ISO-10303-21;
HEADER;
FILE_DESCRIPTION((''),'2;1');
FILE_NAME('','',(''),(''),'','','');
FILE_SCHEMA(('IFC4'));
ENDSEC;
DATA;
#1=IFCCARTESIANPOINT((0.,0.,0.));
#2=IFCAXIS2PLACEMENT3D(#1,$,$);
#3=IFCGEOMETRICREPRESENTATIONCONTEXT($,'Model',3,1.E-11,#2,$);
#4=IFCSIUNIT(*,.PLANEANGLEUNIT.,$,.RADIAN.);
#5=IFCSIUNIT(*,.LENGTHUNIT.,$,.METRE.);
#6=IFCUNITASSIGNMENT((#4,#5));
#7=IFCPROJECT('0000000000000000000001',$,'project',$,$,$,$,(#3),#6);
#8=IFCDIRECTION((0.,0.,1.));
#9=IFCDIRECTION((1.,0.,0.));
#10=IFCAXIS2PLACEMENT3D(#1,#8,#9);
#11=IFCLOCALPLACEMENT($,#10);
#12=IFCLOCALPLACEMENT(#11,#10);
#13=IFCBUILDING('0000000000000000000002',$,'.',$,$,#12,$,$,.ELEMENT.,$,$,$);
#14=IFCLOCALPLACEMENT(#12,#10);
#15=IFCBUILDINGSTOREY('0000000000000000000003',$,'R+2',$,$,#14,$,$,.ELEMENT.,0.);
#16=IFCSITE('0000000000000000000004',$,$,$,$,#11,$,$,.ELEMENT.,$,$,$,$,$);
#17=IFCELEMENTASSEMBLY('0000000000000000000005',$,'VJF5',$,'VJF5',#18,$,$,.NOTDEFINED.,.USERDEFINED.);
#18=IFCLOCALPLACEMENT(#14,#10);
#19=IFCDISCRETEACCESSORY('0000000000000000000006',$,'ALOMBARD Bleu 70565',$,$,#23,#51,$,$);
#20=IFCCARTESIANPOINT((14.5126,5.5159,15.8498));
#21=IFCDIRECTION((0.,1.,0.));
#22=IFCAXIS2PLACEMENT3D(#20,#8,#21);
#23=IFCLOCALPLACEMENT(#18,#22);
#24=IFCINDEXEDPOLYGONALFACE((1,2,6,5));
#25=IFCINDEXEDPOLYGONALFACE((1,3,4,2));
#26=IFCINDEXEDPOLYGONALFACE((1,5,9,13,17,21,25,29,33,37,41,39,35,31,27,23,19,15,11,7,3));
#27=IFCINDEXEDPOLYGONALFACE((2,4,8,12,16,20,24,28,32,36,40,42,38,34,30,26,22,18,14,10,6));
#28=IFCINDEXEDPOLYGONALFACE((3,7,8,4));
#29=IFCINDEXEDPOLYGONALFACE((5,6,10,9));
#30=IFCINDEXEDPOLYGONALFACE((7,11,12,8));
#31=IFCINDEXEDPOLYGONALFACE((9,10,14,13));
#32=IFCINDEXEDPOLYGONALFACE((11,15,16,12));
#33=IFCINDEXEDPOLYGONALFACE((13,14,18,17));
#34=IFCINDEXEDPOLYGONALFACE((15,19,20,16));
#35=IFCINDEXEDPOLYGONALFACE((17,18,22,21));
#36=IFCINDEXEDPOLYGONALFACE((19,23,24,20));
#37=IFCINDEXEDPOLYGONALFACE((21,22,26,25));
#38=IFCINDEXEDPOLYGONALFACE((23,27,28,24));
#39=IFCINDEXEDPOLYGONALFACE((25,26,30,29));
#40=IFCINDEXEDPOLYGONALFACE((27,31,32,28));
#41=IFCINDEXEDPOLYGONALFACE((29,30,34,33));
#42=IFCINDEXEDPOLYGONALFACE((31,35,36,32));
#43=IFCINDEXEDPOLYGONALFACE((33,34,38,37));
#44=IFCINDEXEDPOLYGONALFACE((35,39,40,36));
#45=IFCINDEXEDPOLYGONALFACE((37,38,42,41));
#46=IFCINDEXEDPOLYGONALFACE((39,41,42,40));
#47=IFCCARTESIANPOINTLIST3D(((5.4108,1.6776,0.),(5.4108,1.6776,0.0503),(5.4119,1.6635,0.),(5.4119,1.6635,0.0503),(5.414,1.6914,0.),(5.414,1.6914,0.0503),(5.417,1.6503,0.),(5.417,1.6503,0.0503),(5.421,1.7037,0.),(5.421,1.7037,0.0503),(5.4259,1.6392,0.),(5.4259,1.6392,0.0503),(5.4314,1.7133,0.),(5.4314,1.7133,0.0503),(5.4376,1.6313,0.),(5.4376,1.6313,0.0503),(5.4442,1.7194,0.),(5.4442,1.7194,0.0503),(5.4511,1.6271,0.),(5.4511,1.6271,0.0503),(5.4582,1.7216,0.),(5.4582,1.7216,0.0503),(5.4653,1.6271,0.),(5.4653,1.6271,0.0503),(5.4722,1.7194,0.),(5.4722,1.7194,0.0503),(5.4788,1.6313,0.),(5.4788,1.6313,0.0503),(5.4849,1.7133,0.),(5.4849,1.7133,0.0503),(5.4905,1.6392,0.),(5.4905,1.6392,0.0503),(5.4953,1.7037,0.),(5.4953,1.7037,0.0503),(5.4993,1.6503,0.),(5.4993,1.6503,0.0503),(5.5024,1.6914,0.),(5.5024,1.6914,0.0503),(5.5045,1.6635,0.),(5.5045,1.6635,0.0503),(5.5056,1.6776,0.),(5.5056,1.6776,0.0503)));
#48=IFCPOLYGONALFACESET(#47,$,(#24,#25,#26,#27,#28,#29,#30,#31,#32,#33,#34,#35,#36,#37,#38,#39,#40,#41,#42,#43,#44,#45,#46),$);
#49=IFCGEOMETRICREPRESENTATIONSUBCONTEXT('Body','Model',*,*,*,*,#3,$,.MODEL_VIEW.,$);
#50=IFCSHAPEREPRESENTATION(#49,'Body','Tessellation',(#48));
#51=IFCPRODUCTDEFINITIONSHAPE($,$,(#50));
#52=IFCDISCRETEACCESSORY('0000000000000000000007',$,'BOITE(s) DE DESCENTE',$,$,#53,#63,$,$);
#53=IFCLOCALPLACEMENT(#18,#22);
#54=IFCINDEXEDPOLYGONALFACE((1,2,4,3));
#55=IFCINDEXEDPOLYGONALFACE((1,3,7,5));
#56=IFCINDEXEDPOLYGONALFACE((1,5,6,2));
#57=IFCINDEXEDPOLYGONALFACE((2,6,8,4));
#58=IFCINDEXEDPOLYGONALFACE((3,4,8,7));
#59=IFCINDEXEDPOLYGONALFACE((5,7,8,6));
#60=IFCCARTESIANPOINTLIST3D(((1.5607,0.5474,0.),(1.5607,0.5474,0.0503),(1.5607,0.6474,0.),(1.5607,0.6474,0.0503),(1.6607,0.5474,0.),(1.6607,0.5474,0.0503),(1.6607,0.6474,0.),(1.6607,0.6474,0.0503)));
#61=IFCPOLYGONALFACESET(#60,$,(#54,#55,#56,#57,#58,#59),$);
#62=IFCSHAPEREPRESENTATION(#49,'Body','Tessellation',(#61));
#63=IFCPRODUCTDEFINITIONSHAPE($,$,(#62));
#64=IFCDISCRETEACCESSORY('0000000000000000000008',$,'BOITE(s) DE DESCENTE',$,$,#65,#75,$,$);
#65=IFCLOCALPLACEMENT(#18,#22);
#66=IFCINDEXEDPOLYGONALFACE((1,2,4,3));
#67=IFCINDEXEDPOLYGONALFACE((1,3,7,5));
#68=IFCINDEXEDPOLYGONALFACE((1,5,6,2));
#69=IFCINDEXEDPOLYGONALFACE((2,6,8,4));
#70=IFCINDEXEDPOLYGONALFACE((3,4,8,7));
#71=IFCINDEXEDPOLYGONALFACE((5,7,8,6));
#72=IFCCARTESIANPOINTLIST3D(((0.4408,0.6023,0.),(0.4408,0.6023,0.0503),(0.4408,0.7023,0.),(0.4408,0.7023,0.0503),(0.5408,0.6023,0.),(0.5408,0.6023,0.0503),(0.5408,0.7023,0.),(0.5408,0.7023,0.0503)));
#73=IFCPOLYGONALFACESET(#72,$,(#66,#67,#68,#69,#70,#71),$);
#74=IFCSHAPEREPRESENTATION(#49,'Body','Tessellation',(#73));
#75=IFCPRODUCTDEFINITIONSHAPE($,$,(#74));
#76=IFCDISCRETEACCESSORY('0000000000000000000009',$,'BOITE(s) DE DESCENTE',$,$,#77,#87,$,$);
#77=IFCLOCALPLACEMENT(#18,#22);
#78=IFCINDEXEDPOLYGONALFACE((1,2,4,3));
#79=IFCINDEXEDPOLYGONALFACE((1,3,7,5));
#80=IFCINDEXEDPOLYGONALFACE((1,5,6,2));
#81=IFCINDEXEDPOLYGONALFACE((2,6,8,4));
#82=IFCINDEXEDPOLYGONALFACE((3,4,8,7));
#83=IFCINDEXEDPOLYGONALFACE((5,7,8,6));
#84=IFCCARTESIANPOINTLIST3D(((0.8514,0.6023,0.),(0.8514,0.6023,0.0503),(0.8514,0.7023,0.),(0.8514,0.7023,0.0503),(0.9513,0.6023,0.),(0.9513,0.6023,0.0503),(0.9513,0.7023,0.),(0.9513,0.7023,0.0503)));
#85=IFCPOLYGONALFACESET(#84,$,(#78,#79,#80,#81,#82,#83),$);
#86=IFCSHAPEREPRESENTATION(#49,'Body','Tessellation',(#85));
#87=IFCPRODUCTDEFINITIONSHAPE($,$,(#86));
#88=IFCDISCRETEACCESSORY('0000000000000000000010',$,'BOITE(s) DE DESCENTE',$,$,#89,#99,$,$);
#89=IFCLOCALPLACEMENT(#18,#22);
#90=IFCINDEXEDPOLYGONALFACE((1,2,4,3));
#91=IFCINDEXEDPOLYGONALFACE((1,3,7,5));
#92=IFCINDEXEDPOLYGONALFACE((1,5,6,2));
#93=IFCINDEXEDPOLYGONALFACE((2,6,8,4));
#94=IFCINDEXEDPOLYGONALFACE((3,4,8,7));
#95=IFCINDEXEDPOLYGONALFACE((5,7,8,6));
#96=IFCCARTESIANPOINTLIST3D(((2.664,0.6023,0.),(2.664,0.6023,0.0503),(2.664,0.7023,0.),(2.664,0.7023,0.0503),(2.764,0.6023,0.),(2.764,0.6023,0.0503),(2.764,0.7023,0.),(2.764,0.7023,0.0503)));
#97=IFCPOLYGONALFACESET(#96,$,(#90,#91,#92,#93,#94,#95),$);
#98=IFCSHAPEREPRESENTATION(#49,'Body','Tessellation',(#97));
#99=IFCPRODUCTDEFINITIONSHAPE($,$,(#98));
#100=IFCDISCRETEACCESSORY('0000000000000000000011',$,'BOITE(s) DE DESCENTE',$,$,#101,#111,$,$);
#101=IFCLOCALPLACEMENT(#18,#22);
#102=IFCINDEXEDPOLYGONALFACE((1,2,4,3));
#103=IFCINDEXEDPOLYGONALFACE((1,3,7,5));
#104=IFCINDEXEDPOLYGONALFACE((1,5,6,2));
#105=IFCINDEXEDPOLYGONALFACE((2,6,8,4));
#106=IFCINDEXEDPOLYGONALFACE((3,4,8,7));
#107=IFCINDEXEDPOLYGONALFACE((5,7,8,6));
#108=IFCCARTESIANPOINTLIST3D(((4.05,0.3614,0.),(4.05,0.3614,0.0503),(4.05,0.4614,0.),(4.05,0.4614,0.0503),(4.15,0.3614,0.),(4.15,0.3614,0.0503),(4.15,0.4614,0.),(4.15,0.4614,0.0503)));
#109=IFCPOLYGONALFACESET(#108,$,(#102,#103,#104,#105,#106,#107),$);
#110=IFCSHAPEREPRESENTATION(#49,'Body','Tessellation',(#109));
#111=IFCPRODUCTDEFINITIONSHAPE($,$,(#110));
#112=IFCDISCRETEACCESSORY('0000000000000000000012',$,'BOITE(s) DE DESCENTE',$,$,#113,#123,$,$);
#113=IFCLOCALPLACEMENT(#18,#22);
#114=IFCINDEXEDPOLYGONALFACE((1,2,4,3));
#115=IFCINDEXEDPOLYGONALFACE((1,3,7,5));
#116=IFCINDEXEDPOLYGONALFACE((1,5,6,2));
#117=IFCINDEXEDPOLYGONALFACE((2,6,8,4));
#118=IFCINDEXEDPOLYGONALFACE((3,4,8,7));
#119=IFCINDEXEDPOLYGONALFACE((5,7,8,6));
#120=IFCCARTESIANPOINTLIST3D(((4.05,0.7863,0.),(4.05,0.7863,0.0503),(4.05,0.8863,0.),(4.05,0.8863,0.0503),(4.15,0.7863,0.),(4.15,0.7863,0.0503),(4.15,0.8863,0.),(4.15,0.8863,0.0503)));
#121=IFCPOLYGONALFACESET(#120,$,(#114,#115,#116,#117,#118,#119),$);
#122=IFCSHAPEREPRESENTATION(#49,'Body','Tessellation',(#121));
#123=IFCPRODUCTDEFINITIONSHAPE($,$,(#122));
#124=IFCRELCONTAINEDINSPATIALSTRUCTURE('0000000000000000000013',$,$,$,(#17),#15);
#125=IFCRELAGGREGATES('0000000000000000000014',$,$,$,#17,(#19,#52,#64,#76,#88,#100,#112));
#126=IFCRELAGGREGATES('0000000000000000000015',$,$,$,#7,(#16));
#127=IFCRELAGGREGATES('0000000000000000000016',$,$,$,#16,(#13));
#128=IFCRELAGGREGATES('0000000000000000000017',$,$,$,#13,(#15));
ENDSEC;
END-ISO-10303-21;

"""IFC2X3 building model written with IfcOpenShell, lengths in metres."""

from ifc_helpers import new_model, si_unit, frame, frame_2d, origin, origin_with_axes, place, context, subcontext, project, spatial, polyline, circle, outline, extrude, element, aggregate, save


model = new_model("IFC2X3")

# Units and contexts
model_context = context("Model", 3, precision=1e-11, world=origin())
body_context = subcontext(model_context, "Body", "Model", "MODEL_VIEW")
ifc_project = project(units=[si_unit("PLANEANGLEUNIT", "RADIAN"), si_unit("LENGTHUNIT", "METRE")], contexts=[model_context])

# Site, building, storey
site_placement = place(None, origin_with_axes())
site = spatial("IfcSite", under=ifc_project, at=site_placement, CompositionType="ELEMENT")
building_placement = place(site_placement, origin_with_axes())
building = spatial("IfcBuilding", under=site, at=building_placement, Name=".", CompositionType="ELEMENT")
storey_placement = place(building_placement, origin_with_axes())
storey = spatial("IfcBuildingStorey", under=building, at=storey_placement, Name="R+2", CompositionType="ELEMENT", Elevation=0.0)

# Element assembly, discrete accessories
assembly_placement = place(storey_placement, origin_with_axes())
assembly = element("IfcElementAssembly", 1, at=assembly_placement, inside=storey, Name="VJF5", ObjectType="VJF5", AssemblyPlace="NOTDEFINED", PredefinedType="USERDEFINED")
discrete_accessory_1_placement = place(assembly_placement, frame((14.5126, 5.5159, 15.8498), z_axis=(0.0, 0.0, 1.0), x_axis=(0.0, 1.0, 0.0)))
discrete_accessory_1 = element("IfcDiscreteAccessory", 2, at=discrete_accessory_1_placement, Name="ALOMBARD Bleu 70565", context=body_context, shape_type="SweptSolid", body=[
    extrude(circle(Radius=0.0475, at=frame_2d((1.6741, -5.4582), x_axis=(1.0, 0.0))), frame((0.0, 0.0, 0.0), z_axis=(0.0, 0.0, 1.0), x_axis=(0.0, 1.0, 0.0)), (0.0, 0.0, 1.0), 0.0503),
])
discrete_accessory_2_placement = place(assembly_placement, frame((14.5126, 5.5159, 15.8498), z_axis=(0.0, 0.0, 1.0), x_axis=(0.0, 1.0, 0.0)))
discrete_accessory_2 = element("IfcDiscreteAccessory", 3, at=discrete_accessory_2_placement, Name="BOITE(s) DE DESCENTE", context=body_context, shape_type="SweptSolid", body=[
    extrude(outline(polyline([(0.5474, -1.5607), (0.5474, -1.6607), (0.6474, -1.6607), (0.6474, -1.5607), (0.5474, -1.5607)])), frame((0.0, 0.0, 0.0), z_axis=(0.0, 0.0, 1.0), x_axis=(0.0, 1.0, 0.0)), (0.0, 0.0, 1.0), 0.0503),
])
discrete_accessory_3_placement = place(assembly_placement, frame((14.5126, 5.5159, 15.8498), z_axis=(0.0, 0.0, 1.0), x_axis=(0.0, 1.0, 0.0)))
discrete_accessory_3 = element("IfcDiscreteAccessory", 4, at=discrete_accessory_3_placement, Name="BOITE(s) DE DESCENTE", context=body_context, shape_type="SweptSolid", body=[
    extrude(outline(polyline([(0.6023, -0.4408), (0.6023, -0.5408), (0.7023, -0.5408), (0.7023, -0.4408), (0.6023, -0.4408)])), frame((0.0, 0.0, 0.0), z_axis=(0.0, 0.0, 1.0), x_axis=(0.0, 1.0, 0.0)), (0.0, 0.0, 1.0), 0.0503),
])
discrete_accessory_4_placement = place(assembly_placement, frame((14.5126, 5.5159, 15.8498), z_axis=(0.0, 0.0, 1.0), x_axis=(0.0, 1.0, 0.0)))
discrete_accessory_4 = element("IfcDiscreteAccessory", 5, at=discrete_accessory_4_placement, Name="BOITE(s) DE DESCENTE", context=body_context, shape_type="SweptSolid", body=[
    extrude(outline(polyline([(0.6023, -0.8514), (0.6023, -0.9514), (0.7023, -0.9514), (0.7023, -0.8514), (0.6023, -0.8514)])), frame((0.0, 0.0, 0.0), z_axis=(0.0, 0.0, 1.0), x_axis=(0.0, 1.0, 0.0)), (0.0, 0.0, 1.0), 0.0503),
])
discrete_accessory_5_placement = place(assembly_placement, frame((14.5126, 5.5159, 15.8498), z_axis=(0.0, 0.0, 1.0), x_axis=(0.0, 1.0, 0.0)))
discrete_accessory_5 = element("IfcDiscreteAccessory", 6, at=discrete_accessory_5_placement, Name="BOITE(s) DE DESCENTE", context=body_context, shape_type="SweptSolid", body=[
    extrude(outline(polyline([(0.6023, -2.664), (0.6023, -2.764), (0.7023, -2.764), (0.7023, -2.664), (0.6023, -2.664)])), frame((0.0, 0.0, 0.0), z_axis=(0.0, 0.0, 1.0), x_axis=(0.0, 1.0, 0.0)), (0.0, 0.0, 1.0), 0.0503),
])
discrete_accessory_6_placement = place(assembly_placement, frame((14.5126, 5.5159, 15.8498), z_axis=(0.0, 0.0, 1.0), x_axis=(0.0, 1.0, 0.0)))
discrete_accessory_6 = element("IfcDiscreteAccessory", 7, at=discrete_accessory_6_placement, Name="BOITE(s) DE DESCENTE", context=body_context, shape_type="SweptSolid", body=[
    extrude(outline(polyline([(0.3614, -4.05), (0.3614, -4.15), (0.4614, -4.15), (0.4614, -4.05), (0.3614, -4.05)])), frame((0.0, 0.0, 0.0), z_axis=(0.0, 0.0, 1.0), x_axis=(0.0, 1.0, 0.0)), (0.0, 0.0, 1.0), 0.0503),
])
discrete_accessory_7_placement = place(assembly_placement, frame((14.5126, 5.5159, 15.8498), z_axis=(0.0, 0.0, 1.0), x_axis=(0.0, 1.0, 0.0)))
discrete_accessory_7 = element("IfcDiscreteAccessory", 8, at=discrete_accessory_7_placement, Name="BOITE(s) DE DESCENTE", context=body_context, shape_type="SweptSolid", body=[
    extrude(outline(polyline([(0.7863, -4.05), (0.7863, -4.15), (0.8863, -4.15), (0.8863, -4.05), (0.7863, -4.05)])), frame((0.0, 0.0, 0.0), z_axis=(0.0, 0.0, 1.0), x_axis=(0.0, 1.0, 0.0)), (0.0, 0.0, 1.0), 0.0503),
])
aggregate(assembly, [discrete_accessory_1, discrete_accessory_2, discrete_accessory_3, discrete_accessory_4, discrete_accessory_5, discrete_accessory_6, discrete_accessory_7])

save(model, "model.ifc")
